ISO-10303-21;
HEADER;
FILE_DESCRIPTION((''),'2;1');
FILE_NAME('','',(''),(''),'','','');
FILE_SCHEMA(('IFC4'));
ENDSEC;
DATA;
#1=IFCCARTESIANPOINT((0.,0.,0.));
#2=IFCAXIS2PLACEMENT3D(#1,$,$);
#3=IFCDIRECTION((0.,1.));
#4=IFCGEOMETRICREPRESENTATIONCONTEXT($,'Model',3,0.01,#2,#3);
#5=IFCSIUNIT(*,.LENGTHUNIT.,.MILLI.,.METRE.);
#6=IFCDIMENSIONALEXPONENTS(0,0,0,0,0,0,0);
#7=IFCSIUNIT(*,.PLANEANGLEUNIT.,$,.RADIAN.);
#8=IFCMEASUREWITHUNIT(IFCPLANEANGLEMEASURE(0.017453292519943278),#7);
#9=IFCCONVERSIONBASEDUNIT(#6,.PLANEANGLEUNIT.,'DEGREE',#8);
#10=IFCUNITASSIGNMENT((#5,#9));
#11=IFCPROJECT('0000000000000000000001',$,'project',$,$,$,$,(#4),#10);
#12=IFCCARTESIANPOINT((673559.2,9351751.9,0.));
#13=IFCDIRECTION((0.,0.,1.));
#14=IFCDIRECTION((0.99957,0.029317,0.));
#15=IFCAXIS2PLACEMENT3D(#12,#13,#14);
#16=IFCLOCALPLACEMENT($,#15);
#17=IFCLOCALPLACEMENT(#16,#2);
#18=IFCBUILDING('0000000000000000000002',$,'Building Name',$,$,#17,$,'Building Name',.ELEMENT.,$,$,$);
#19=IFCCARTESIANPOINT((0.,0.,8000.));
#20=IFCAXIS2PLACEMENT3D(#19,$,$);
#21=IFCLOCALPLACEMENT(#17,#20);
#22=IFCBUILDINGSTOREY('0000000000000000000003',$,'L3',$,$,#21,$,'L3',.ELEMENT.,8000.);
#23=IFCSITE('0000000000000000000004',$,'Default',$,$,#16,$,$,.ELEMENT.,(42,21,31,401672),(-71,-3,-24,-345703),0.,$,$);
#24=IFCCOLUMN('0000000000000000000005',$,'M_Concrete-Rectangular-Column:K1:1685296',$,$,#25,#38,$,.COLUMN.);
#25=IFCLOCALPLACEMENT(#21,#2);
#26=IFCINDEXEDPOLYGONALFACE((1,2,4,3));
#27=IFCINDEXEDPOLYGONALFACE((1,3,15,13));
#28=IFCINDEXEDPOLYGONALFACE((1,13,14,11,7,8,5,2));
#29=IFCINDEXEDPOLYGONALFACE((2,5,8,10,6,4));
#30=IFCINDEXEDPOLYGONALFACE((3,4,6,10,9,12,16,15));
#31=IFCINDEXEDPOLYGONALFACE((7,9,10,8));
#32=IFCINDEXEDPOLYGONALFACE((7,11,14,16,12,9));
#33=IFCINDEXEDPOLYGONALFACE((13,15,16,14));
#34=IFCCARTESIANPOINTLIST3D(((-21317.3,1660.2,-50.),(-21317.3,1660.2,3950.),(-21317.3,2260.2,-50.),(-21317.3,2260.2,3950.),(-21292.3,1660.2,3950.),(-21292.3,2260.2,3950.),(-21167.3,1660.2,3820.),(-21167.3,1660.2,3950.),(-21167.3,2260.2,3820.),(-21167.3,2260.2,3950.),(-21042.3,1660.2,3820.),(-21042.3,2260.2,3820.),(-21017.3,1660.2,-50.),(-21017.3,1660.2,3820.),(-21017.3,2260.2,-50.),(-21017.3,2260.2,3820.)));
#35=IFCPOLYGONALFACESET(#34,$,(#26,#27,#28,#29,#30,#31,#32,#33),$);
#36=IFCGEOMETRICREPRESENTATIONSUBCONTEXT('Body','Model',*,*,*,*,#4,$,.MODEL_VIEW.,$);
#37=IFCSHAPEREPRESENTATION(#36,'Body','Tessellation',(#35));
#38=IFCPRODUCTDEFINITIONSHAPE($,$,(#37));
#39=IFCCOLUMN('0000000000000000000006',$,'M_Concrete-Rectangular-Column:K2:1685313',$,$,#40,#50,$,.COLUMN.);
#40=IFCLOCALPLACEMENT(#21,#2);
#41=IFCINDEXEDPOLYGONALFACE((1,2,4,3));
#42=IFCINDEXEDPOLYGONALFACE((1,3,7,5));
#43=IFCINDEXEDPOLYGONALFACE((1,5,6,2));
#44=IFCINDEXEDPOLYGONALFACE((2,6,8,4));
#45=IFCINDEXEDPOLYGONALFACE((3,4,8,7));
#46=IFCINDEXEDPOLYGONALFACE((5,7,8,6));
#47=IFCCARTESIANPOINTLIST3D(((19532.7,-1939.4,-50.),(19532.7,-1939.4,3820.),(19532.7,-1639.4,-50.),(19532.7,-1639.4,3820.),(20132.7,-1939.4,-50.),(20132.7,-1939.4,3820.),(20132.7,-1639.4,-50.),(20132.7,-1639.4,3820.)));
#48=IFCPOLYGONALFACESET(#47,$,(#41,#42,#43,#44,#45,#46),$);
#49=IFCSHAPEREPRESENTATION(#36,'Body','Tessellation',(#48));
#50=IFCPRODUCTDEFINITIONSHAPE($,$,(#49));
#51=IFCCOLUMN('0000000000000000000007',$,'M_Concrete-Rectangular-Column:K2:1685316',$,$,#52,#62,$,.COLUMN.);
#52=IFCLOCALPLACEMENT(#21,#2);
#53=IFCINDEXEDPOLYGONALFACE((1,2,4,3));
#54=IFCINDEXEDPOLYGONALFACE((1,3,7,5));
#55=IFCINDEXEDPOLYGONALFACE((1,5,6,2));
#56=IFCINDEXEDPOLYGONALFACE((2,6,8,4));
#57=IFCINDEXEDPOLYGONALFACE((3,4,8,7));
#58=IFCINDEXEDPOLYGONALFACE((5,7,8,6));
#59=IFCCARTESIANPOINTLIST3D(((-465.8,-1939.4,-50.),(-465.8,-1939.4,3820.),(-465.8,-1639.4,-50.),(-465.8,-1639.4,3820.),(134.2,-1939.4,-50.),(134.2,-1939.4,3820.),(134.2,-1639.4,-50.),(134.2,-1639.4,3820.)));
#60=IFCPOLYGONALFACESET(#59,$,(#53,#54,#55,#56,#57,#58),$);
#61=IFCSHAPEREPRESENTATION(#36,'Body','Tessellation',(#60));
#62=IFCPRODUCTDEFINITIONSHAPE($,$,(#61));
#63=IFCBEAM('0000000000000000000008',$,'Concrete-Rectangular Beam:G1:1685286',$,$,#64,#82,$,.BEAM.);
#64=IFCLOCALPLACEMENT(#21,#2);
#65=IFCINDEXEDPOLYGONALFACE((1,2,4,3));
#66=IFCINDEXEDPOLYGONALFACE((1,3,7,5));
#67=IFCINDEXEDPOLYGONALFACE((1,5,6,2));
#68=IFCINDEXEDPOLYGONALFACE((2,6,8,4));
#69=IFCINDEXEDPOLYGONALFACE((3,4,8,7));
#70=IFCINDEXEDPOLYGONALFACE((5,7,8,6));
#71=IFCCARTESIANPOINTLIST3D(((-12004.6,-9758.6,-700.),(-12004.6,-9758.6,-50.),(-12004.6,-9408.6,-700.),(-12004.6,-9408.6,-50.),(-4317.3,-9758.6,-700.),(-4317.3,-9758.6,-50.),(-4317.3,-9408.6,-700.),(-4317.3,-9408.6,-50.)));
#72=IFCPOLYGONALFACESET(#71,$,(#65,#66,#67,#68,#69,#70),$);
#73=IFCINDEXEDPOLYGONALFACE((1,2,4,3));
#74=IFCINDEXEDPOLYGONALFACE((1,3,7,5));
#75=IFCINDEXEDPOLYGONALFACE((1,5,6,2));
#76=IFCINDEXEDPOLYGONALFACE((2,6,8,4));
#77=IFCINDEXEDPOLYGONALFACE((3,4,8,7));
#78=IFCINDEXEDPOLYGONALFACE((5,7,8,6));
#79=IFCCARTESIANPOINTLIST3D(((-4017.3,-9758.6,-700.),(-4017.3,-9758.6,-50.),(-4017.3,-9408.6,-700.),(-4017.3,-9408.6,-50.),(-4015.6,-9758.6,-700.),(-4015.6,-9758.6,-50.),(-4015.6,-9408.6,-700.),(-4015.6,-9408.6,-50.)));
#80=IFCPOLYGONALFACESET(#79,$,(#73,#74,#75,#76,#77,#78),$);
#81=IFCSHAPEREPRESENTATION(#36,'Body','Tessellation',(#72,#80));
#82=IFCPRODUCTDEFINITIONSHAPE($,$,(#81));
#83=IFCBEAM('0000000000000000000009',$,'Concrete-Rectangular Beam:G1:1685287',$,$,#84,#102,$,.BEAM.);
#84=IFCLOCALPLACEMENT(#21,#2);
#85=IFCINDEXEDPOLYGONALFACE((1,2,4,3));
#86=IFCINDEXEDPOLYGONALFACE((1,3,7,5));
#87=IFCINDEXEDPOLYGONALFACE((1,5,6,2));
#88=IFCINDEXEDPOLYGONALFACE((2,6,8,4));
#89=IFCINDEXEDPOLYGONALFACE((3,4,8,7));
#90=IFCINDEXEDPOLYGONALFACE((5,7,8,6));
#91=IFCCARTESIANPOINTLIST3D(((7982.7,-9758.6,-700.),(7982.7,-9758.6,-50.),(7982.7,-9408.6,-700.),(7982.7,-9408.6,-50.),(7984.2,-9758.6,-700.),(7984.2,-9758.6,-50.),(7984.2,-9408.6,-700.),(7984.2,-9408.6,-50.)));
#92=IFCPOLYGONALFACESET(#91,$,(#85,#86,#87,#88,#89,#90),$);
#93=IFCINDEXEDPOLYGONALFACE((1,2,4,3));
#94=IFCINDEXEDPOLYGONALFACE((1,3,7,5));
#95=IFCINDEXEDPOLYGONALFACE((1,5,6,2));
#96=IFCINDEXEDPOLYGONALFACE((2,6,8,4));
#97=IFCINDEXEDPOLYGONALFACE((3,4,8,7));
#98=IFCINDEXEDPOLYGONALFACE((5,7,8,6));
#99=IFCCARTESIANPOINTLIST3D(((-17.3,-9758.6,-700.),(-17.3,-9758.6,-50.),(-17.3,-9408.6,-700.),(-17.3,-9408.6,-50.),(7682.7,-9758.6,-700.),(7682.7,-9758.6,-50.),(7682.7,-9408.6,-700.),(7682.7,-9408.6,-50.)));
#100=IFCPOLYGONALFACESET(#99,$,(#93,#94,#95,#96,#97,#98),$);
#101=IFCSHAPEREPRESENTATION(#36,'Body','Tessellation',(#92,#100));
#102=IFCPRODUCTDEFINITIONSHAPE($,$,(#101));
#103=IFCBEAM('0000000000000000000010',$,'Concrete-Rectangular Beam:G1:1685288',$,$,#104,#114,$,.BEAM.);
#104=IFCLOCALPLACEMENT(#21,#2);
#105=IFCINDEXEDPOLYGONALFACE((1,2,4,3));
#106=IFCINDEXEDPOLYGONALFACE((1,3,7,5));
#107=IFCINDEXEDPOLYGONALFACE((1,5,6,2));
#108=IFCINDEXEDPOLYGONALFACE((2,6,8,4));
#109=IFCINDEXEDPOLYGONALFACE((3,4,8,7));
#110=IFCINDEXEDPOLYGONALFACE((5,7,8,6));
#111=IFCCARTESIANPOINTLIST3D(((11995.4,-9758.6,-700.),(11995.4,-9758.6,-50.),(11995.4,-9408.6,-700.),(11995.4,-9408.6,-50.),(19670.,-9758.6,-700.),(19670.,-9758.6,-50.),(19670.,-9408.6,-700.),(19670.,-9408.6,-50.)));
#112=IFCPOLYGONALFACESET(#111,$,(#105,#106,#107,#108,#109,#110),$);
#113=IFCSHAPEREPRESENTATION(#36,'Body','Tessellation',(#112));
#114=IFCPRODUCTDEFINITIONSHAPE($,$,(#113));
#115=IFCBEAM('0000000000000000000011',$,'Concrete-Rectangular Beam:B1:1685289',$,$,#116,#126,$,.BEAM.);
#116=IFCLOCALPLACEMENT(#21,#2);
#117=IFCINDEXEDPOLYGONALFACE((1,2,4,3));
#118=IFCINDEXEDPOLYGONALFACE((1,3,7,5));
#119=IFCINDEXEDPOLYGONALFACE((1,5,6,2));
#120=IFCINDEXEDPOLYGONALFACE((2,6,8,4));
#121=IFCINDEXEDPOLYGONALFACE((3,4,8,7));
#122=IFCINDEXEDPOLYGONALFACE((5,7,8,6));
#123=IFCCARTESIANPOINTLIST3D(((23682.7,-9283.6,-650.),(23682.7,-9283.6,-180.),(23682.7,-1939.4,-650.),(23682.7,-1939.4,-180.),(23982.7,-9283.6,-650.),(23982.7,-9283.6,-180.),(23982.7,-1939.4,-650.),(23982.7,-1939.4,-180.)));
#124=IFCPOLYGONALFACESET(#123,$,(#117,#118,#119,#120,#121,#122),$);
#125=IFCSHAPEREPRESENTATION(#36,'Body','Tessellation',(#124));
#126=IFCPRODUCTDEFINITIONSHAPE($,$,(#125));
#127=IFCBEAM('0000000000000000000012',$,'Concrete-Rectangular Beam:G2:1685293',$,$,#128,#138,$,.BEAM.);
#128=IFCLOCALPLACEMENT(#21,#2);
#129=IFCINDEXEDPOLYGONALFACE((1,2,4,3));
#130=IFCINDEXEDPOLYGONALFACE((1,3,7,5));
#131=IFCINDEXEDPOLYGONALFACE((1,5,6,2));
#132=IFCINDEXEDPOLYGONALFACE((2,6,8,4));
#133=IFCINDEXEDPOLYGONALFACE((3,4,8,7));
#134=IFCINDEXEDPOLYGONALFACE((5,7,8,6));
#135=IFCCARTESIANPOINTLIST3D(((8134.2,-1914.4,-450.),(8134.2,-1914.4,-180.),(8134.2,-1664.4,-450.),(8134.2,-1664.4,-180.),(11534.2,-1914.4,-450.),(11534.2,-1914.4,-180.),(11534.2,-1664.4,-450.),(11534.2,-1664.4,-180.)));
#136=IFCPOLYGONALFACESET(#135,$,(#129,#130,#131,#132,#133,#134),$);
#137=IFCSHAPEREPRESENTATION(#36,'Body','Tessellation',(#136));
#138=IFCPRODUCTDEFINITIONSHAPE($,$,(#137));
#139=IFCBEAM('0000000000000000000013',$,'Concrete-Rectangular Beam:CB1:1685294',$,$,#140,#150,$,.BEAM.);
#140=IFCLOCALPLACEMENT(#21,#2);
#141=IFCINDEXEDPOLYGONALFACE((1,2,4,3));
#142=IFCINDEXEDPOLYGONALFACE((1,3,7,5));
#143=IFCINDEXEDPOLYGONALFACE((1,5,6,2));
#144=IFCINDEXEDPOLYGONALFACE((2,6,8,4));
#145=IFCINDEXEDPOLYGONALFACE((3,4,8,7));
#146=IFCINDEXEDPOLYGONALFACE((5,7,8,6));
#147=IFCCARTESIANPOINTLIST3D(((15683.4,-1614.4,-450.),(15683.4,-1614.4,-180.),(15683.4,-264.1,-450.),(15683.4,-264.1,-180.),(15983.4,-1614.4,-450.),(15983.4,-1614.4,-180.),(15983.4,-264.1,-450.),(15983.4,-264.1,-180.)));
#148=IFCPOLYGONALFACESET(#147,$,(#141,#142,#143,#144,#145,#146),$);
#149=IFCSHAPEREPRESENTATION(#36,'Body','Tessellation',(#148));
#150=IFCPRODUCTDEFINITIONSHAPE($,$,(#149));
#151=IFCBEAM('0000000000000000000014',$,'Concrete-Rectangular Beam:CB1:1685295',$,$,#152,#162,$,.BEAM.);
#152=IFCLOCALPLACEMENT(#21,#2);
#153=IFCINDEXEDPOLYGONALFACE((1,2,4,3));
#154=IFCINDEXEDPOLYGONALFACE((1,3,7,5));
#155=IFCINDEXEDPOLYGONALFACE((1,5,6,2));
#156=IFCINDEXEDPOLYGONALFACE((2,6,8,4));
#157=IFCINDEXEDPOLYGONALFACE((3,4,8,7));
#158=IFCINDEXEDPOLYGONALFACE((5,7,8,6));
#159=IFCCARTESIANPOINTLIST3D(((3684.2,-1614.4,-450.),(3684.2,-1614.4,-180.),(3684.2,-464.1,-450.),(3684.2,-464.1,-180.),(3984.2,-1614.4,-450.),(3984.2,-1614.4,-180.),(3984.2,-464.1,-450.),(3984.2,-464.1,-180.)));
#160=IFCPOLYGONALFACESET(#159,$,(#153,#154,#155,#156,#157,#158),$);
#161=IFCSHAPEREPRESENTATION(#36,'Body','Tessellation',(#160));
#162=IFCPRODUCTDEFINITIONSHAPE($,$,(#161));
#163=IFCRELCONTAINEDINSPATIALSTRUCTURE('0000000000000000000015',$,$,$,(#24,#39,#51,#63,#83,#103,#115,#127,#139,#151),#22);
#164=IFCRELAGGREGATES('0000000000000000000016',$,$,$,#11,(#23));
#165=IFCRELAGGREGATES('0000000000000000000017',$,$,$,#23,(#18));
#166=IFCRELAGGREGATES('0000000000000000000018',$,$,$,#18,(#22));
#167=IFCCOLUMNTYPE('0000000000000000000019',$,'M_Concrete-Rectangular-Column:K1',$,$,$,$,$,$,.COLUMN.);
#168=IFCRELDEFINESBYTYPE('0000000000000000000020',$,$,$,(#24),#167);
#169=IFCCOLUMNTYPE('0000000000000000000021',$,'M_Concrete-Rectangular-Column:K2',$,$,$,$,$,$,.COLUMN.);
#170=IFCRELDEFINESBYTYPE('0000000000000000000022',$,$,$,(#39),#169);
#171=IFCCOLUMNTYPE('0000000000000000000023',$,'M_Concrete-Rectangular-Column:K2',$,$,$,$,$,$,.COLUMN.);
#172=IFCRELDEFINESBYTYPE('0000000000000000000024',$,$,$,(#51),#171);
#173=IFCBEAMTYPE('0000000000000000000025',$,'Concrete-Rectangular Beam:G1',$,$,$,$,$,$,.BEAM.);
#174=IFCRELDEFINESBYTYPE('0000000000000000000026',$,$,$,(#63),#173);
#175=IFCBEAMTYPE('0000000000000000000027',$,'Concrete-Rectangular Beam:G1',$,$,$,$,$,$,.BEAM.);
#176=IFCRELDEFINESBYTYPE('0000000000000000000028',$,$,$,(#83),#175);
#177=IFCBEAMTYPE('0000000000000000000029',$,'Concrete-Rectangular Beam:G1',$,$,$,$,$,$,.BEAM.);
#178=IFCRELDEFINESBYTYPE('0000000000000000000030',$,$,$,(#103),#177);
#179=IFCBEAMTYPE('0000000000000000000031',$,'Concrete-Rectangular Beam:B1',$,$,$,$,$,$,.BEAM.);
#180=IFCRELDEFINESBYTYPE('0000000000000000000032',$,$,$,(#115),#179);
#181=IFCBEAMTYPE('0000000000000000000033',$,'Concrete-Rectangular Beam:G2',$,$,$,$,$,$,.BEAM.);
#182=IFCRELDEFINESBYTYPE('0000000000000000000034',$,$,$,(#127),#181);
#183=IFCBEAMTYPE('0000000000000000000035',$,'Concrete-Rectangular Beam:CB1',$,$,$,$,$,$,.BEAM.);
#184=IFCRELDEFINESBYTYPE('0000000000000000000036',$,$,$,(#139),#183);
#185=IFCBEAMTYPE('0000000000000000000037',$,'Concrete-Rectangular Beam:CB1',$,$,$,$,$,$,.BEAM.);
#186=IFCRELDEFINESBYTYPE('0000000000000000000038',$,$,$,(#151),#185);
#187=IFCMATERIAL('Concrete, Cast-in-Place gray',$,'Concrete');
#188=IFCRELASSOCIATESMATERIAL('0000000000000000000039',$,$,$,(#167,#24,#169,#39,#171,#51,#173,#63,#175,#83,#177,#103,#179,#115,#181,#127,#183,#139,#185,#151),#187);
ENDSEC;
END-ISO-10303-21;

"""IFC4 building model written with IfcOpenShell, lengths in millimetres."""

from ifc_helpers import new_model, entity, si_unit, converted_unit, direction, frame, origin, place, context, subcontext, project, spatial, indexed_curve, outline, extrude, source, transform, mapped, material, type_object, type_shapes, element, save


model = new_model("IFC4")

# Units and contexts
model_context = context("Model", 3, precision=0.01, world=origin(), true_north=direction((0.0, 1.0)))
body_context = subcontext(model_context, "Body", "Model", "MODEL_VIEW")
ifc_project = project(units=[si_unit("LENGTHUNIT", "METRE", prefix="MILLI"), converted_unit("PLANEANGLEUNIT", "DEGREE", entity("IfcPlaneAngleMeasure", 0.017453292519943278), si_unit("PLANEANGLEUNIT", "RADIAN"), dimensions=[0, 0, 0, 0, 0, 0, 0])], contexts=[model_context])

# Site, building, storey
site_placement = place(None, frame((673559.2, 9351751.9, 0.0), z_axis=(0.0, 0.0, 1.0), x_axis=(0.99957, 0.029317, 0.0)))
site = spatial("IfcSite", under=ifc_project, at=site_placement, Name="Default", CompositionType="ELEMENT", RefLatitude=(42, 21, 31, 401672), RefLongitude=(-71, -3, -24, -345703), RefElevation=0.0)
building_placement = place(site_placement, origin())
building = spatial("IfcBuilding", under=site, at=building_placement, Name="Building Name", LongName="Building Name", CompositionType="ELEMENT")
storey_placement = place(building_placement, frame((0.0, 0.0, 8000.0)))
storey = spatial("IfcBuildingStorey", under=building, at=storey_placement, Name="L3", LongName="L3", CompositionType="ELEMENT", Elevation=8000.0)

# Columns
ifc_material = material(Name="Concrete, Cast-in-Place gray", Category="Concrete")
column_type_1 = type_object("IfcColumnType", Name="M_Concrete-Rectangular-Column:K1", PredefinedType="COLUMN", material=ifc_material)
shared_shape_1 = source(origin(), body_context, "Body", "SweptSolid", [
    extrude(outline(indexed_curve([(-2951.2, -150.0), (1048.8, -150.0), (1048.8, -125.0), (1048.8, 0.0), (918.8, 0.0), (918.8, 125.0), (918.8, 150.0), (-2951.2, 150.0), (-2951.2, -150.0)], self_intersect=False)), frame((-21167.3, 1660.2, 10901.2), z_axis=(0.0, 1.0, 0.0), x_axis=(0.0, 0.0, 1.0)), (0.0, 0.0, 1.0), 600.0),
])
type_shapes(column_type_1, [shared_shape_1])
column_1_placement = place(storey_placement, frame((0.0, 0.0, -8000.0)))
element("IfcColumn", 1, at=column_1_placement, inside=storey, type_object=column_type_1, material=ifc_material, Name="M_Concrete-Rectangular-Column:K1:1685296", PredefinedType="COLUMN", context=body_context, shape_type="MappedRepresentation", body=[
    mapped(shared_shape_1, transform((0.0, 0.0, 0.0), scale=1.0)),
])
column_type_2 = type_object("IfcColumnType", Name="M_Concrete-Rectangular-Column:K2", PredefinedType="COLUMN", material=ifc_material)
shared_shape_2 = source(origin(), body_context, "Body", "SweptSolid", [
    extrude(outline(indexed_curve([(-150.0, -300.0), (150.0, -300.0), (150.0, 300.0), (-150.0, 300.0), (-150.0, -300.0)], self_intersect=False)), frame((19832.7, -1789.4, 7950.0), z_axis=(0.0, 0.0, 1.0), x_axis=(0.0, -1.0, 0.0)), (0.0, 0.0, 1.0), 3870.0),
])
type_shapes(column_type_2, [shared_shape_2])
column_2_placement = place(storey_placement, frame((0.0, 0.0, -8000.0)))
element("IfcColumn", 2, at=column_2_placement, inside=storey, type_object=column_type_2, material=ifc_material, Name="M_Concrete-Rectangular-Column:K2:1685313", PredefinedType="COLUMN", context=body_context, shape_type="MappedRepresentation", body=[
    mapped(shared_shape_2, transform((0.0, 0.0, 0.0), scale=1.0)),
])
column_type_3 = type_object("IfcColumnType", Name="M_Concrete-Rectangular-Column:K2", PredefinedType="COLUMN", material=ifc_material)
shared_shape_3 = source(origin(), body_context, "Body", "SweptSolid", [
    extrude(outline(indexed_curve([(-150.0, -300.0), (150.0, -300.0), (150.0, 300.0), (-150.0, 300.0), (-150.0, -300.0)], self_intersect=False)), frame((-165.8, -1789.4, 7950.0), z_axis=(0.0, 0.0, 1.0), x_axis=(0.0, -1.0, 0.0)), (0.0, 0.0, 1.0), 3870.0),
])
type_shapes(column_type_3, [shared_shape_3])
column_3_placement = place(storey_placement, frame((0.0, 0.0, -8000.0)))
element("IfcColumn", 3, at=column_3_placement, inside=storey, type_object=column_type_3, material=ifc_material, Name="M_Concrete-Rectangular-Column:K2:1685316", PredefinedType="COLUMN", context=body_context, shape_type="MappedRepresentation", body=[
    mapped(shared_shape_3, transform((0.0, 0.0, 0.0), scale=1.0)),
])

# Beams
beam_type_1 = type_object("IfcBeamType", Name="Concrete-Rectangular Beam:G1", PredefinedType="BEAM", material=ifc_material)
shared_shape_4 = source(origin(), body_context, "Body", "SweptSolid", [
    extrude(outline(indexed_curve([(-325.0, -175.0), (325.0, -175.0), (325.0, 175.0), (-325.0, 175.0), (-325.0, -175.0)], self_intersect=False)), frame((-12004.6, -9583.6, 7625.0), z_axis=(1.0, 0.0, 0.0), x_axis=(0.0, 0.0, -1.0)), (0.0, 0.0, 1.0), 7687.3),
    extrude(outline(indexed_curve([(-325.0, -175.0), (325.0, -175.0), (325.0, 175.0), (-325.0, 175.0), (-325.0, -175.0)], self_intersect=False)), frame((-4017.3, -9583.6, 7625.0), z_axis=(1.0, 0.0, 0.0), x_axis=(0.0, 0.0, -1.0)), (0.0, 0.0, 1.0), 1.8),
])
type_shapes(beam_type_1, [shared_shape_4])
beam_1_placement = place(storey_placement, frame((0.0, 0.0, -8000.0)))
element("IfcBeam", 4, at=beam_1_placement, inside=storey, type_object=beam_type_1, material=ifc_material, Name="Concrete-Rectangular Beam:G1:1685286", PredefinedType="BEAM", context=body_context, shape_type="MappedRepresentation", body=[
    mapped(shared_shape_4, transform((0.0, 0.0, 0.0), scale=1.0)),
])
beam_type_2 = type_object("IfcBeamType", Name="Concrete-Rectangular Beam:G1", PredefinedType="BEAM", material=ifc_material)
shared_shape_5 = source(origin(), body_context, "Body", "SweptSolid", [
    extrude(outline(indexed_curve([(-325.0, -175.0), (325.0, -175.0), (325.0, 175.0), (-325.0, 175.0), (-325.0, -175.0)], self_intersect=False)), frame((7982.7, -9583.6, 7625.0), z_axis=(1.0, 0.0, 0.0), x_axis=(0.0, 0.0, -1.0)), (0.0, 0.0, 1.0), 1.5),
    extrude(outline(indexed_curve([(-325.0, -175.0), (325.0, -175.0), (325.0, 175.0), (-325.0, 175.0), (-325.0, -175.0)], self_intersect=False)), frame((-17.3, -9583.6, 7625.0), z_axis=(1.0, 0.0, 0.0), x_axis=(0.0, 0.0, -1.0)), (0.0, 0.0, 1.0), 7700.0),
])
type_shapes(beam_type_2, [shared_shape_5])
beam_2_placement = place(storey_placement, frame((0.0, 0.0, -8000.0)))
element("IfcBeam", 5, at=beam_2_placement, inside=storey, type_object=beam_type_2, material=ifc_material, Name="Concrete-Rectangular Beam:G1:1685287", PredefinedType="BEAM", context=body_context, shape_type="MappedRepresentation", body=[
    mapped(shared_shape_5, transform((0.0, 0.0, 0.0), scale=1.0)),
])
beam_type_3 = type_object("IfcBeamType", Name="Concrete-Rectangular Beam:G1", PredefinedType="BEAM", material=ifc_material)
shared_shape_6 = source(origin(), body_context, "Body", "SweptSolid", [
    extrude(outline(indexed_curve([(-325.0, -175.0), (325.0, -175.0), (325.0, 175.0), (-325.0, 175.0), (-325.0, -175.0)], self_intersect=False)), frame((11995.4, -9583.6, 7625.0), z_axis=(1.0, 0.0, 0.0), x_axis=(0.0, 0.0, -1.0)), (0.0, 0.0, 1.0), 7674.6),
])
type_shapes(beam_type_3, [shared_shape_6])
beam_3_placement = place(storey_placement, frame((0.0, 0.0, -8000.0)))
element("IfcBeam", 6, at=beam_3_placement, inside=storey, type_object=beam_type_3, material=ifc_material, Name="Concrete-Rectangular Beam:G1:1685288", PredefinedType="BEAM", context=body_context, shape_type="MappedRepresentation", body=[
    mapped(shared_shape_6, transform((0.0, 0.0, 0.0), scale=1.0)),
])
beam_type_4 = type_object("IfcBeamType", Name="Concrete-Rectangular Beam:B1", PredefinedType="BEAM", material=ifc_material)
shared_shape_7 = source(origin(), body_context, "Body", "SweptSolid", [
    extrude(outline(indexed_curve([(-150.0, -235.0), (150.0, -235.0), (150.0, 235.0), (-150.0, 235.0), (-150.0, -235.0)], self_intersect=False)), frame((23832.7, -9283.6, 7585.0), z_axis=(0.0, 1.0, 0.0), x_axis=(-1.0, 0.0, 0.0)), (0.0, 0.0, 1.0), 7344.1),
])
type_shapes(beam_type_4, [shared_shape_7])
beam_4_placement = place(storey_placement, frame((0.0, 0.0, -8000.0)))
element("IfcBeam", 7, at=beam_4_placement, inside=storey, type_object=beam_type_4, material=ifc_material, Name="Concrete-Rectangular Beam:B1:1685289", PredefinedType="BEAM", context=body_context, shape_type="MappedRepresentation", body=[
    mapped(shared_shape_7, transform((0.0, 0.0, 0.0), scale=1.0)),
])
beam_type_5 = type_object("IfcBeamType", Name="Concrete-Rectangular Beam:G2", PredefinedType="BEAM", material=ifc_material)
shared_shape_8 = source(origin(), body_context, "Body", "SweptSolid", [
    extrude(outline(indexed_curve([(-135.0, -125.0), (135.0, -125.0), (135.0, 125.0), (-135.0, 125.0), (-135.0, -125.0)], self_intersect=False)), frame((8134.2, -1789.4, 7685.0), z_axis=(1.0, 0.0, 0.0), x_axis=(0.0, 0.0, -1.0)), (0.0, 0.0, 1.0), 3400.0),
])
type_shapes(beam_type_5, [shared_shape_8])
beam_5_placement = place(storey_placement, frame((0.0, 0.0, -8000.0)))
element("IfcBeam", 8, at=beam_5_placement, inside=storey, type_object=beam_type_5, material=ifc_material, Name="Concrete-Rectangular Beam:G2:1685293", PredefinedType="BEAM", context=body_context, shape_type="MappedRepresentation", body=[
    mapped(shared_shape_8, transform((0.0, 0.0, 0.0), scale=1.0)),
])
beam_type_6 = type_object("IfcBeamType", Name="Concrete-Rectangular Beam:CB1", PredefinedType="BEAM", material=ifc_material)
shared_shape_9 = source(origin(), body_context, "Body", "SweptSolid", [
    extrude(outline(indexed_curve([(-150.0, -135.0), (150.0, -135.0), (150.0, 135.0), (-150.0, 135.0), (-150.0, -135.0)], self_intersect=False)), frame((15833.4, -1614.4, 7685.0), z_axis=(0.0, 1.0, 0.0), x_axis=(-1.0, 0.0, 0.0)), (0.0, 0.0, 1.0), 1350.4),
])
type_shapes(beam_type_6, [shared_shape_9])
beam_6_placement = place(storey_placement, frame((0.0, 0.0, -8000.0)))
element("IfcBeam", 9, at=beam_6_placement, inside=storey, type_object=beam_type_6, material=ifc_material, Name="Concrete-Rectangular Beam:CB1:1685294", PredefinedType="BEAM", context=body_context, shape_type="MappedRepresentation", body=[
    mapped(shared_shape_9, transform((0.0, 0.0, 0.0), scale=1.0)),
])
beam_type_7 = type_object("IfcBeamType", Name="Concrete-Rectangular Beam:CB1", PredefinedType="BEAM", material=ifc_material)
shared_shape_10 = source(origin(), body_context, "Body", "SweptSolid", [
    extrude(outline(indexed_curve([(-150.0, -135.0), (150.0, -135.0), (150.0, 135.0), (-150.0, 135.0), (-150.0, -135.0)], self_intersect=False)), frame((3834.2, -1614.4, 7685.0), z_axis=(0.0, 1.0, 0.0), x_axis=(-1.0, 0.0, 0.0)), (0.0, 0.0, 1.0), 1150.4),
])
type_shapes(beam_type_7, [shared_shape_10])
beam_7_placement = place(storey_placement, frame((0.0, 0.0, -8000.0)))
element("IfcBeam", 10, at=beam_7_placement, inside=storey, type_object=beam_type_7, material=ifc_material, Name="Concrete-Rectangular Beam:CB1:1685295", PredefinedType="BEAM", context=body_context, shape_type="MappedRepresentation", body=[
    mapped(shared_shape_10, transform((0.0, 0.0, 0.0), scale=1.0)),
])

save(model, "model.ifc")
